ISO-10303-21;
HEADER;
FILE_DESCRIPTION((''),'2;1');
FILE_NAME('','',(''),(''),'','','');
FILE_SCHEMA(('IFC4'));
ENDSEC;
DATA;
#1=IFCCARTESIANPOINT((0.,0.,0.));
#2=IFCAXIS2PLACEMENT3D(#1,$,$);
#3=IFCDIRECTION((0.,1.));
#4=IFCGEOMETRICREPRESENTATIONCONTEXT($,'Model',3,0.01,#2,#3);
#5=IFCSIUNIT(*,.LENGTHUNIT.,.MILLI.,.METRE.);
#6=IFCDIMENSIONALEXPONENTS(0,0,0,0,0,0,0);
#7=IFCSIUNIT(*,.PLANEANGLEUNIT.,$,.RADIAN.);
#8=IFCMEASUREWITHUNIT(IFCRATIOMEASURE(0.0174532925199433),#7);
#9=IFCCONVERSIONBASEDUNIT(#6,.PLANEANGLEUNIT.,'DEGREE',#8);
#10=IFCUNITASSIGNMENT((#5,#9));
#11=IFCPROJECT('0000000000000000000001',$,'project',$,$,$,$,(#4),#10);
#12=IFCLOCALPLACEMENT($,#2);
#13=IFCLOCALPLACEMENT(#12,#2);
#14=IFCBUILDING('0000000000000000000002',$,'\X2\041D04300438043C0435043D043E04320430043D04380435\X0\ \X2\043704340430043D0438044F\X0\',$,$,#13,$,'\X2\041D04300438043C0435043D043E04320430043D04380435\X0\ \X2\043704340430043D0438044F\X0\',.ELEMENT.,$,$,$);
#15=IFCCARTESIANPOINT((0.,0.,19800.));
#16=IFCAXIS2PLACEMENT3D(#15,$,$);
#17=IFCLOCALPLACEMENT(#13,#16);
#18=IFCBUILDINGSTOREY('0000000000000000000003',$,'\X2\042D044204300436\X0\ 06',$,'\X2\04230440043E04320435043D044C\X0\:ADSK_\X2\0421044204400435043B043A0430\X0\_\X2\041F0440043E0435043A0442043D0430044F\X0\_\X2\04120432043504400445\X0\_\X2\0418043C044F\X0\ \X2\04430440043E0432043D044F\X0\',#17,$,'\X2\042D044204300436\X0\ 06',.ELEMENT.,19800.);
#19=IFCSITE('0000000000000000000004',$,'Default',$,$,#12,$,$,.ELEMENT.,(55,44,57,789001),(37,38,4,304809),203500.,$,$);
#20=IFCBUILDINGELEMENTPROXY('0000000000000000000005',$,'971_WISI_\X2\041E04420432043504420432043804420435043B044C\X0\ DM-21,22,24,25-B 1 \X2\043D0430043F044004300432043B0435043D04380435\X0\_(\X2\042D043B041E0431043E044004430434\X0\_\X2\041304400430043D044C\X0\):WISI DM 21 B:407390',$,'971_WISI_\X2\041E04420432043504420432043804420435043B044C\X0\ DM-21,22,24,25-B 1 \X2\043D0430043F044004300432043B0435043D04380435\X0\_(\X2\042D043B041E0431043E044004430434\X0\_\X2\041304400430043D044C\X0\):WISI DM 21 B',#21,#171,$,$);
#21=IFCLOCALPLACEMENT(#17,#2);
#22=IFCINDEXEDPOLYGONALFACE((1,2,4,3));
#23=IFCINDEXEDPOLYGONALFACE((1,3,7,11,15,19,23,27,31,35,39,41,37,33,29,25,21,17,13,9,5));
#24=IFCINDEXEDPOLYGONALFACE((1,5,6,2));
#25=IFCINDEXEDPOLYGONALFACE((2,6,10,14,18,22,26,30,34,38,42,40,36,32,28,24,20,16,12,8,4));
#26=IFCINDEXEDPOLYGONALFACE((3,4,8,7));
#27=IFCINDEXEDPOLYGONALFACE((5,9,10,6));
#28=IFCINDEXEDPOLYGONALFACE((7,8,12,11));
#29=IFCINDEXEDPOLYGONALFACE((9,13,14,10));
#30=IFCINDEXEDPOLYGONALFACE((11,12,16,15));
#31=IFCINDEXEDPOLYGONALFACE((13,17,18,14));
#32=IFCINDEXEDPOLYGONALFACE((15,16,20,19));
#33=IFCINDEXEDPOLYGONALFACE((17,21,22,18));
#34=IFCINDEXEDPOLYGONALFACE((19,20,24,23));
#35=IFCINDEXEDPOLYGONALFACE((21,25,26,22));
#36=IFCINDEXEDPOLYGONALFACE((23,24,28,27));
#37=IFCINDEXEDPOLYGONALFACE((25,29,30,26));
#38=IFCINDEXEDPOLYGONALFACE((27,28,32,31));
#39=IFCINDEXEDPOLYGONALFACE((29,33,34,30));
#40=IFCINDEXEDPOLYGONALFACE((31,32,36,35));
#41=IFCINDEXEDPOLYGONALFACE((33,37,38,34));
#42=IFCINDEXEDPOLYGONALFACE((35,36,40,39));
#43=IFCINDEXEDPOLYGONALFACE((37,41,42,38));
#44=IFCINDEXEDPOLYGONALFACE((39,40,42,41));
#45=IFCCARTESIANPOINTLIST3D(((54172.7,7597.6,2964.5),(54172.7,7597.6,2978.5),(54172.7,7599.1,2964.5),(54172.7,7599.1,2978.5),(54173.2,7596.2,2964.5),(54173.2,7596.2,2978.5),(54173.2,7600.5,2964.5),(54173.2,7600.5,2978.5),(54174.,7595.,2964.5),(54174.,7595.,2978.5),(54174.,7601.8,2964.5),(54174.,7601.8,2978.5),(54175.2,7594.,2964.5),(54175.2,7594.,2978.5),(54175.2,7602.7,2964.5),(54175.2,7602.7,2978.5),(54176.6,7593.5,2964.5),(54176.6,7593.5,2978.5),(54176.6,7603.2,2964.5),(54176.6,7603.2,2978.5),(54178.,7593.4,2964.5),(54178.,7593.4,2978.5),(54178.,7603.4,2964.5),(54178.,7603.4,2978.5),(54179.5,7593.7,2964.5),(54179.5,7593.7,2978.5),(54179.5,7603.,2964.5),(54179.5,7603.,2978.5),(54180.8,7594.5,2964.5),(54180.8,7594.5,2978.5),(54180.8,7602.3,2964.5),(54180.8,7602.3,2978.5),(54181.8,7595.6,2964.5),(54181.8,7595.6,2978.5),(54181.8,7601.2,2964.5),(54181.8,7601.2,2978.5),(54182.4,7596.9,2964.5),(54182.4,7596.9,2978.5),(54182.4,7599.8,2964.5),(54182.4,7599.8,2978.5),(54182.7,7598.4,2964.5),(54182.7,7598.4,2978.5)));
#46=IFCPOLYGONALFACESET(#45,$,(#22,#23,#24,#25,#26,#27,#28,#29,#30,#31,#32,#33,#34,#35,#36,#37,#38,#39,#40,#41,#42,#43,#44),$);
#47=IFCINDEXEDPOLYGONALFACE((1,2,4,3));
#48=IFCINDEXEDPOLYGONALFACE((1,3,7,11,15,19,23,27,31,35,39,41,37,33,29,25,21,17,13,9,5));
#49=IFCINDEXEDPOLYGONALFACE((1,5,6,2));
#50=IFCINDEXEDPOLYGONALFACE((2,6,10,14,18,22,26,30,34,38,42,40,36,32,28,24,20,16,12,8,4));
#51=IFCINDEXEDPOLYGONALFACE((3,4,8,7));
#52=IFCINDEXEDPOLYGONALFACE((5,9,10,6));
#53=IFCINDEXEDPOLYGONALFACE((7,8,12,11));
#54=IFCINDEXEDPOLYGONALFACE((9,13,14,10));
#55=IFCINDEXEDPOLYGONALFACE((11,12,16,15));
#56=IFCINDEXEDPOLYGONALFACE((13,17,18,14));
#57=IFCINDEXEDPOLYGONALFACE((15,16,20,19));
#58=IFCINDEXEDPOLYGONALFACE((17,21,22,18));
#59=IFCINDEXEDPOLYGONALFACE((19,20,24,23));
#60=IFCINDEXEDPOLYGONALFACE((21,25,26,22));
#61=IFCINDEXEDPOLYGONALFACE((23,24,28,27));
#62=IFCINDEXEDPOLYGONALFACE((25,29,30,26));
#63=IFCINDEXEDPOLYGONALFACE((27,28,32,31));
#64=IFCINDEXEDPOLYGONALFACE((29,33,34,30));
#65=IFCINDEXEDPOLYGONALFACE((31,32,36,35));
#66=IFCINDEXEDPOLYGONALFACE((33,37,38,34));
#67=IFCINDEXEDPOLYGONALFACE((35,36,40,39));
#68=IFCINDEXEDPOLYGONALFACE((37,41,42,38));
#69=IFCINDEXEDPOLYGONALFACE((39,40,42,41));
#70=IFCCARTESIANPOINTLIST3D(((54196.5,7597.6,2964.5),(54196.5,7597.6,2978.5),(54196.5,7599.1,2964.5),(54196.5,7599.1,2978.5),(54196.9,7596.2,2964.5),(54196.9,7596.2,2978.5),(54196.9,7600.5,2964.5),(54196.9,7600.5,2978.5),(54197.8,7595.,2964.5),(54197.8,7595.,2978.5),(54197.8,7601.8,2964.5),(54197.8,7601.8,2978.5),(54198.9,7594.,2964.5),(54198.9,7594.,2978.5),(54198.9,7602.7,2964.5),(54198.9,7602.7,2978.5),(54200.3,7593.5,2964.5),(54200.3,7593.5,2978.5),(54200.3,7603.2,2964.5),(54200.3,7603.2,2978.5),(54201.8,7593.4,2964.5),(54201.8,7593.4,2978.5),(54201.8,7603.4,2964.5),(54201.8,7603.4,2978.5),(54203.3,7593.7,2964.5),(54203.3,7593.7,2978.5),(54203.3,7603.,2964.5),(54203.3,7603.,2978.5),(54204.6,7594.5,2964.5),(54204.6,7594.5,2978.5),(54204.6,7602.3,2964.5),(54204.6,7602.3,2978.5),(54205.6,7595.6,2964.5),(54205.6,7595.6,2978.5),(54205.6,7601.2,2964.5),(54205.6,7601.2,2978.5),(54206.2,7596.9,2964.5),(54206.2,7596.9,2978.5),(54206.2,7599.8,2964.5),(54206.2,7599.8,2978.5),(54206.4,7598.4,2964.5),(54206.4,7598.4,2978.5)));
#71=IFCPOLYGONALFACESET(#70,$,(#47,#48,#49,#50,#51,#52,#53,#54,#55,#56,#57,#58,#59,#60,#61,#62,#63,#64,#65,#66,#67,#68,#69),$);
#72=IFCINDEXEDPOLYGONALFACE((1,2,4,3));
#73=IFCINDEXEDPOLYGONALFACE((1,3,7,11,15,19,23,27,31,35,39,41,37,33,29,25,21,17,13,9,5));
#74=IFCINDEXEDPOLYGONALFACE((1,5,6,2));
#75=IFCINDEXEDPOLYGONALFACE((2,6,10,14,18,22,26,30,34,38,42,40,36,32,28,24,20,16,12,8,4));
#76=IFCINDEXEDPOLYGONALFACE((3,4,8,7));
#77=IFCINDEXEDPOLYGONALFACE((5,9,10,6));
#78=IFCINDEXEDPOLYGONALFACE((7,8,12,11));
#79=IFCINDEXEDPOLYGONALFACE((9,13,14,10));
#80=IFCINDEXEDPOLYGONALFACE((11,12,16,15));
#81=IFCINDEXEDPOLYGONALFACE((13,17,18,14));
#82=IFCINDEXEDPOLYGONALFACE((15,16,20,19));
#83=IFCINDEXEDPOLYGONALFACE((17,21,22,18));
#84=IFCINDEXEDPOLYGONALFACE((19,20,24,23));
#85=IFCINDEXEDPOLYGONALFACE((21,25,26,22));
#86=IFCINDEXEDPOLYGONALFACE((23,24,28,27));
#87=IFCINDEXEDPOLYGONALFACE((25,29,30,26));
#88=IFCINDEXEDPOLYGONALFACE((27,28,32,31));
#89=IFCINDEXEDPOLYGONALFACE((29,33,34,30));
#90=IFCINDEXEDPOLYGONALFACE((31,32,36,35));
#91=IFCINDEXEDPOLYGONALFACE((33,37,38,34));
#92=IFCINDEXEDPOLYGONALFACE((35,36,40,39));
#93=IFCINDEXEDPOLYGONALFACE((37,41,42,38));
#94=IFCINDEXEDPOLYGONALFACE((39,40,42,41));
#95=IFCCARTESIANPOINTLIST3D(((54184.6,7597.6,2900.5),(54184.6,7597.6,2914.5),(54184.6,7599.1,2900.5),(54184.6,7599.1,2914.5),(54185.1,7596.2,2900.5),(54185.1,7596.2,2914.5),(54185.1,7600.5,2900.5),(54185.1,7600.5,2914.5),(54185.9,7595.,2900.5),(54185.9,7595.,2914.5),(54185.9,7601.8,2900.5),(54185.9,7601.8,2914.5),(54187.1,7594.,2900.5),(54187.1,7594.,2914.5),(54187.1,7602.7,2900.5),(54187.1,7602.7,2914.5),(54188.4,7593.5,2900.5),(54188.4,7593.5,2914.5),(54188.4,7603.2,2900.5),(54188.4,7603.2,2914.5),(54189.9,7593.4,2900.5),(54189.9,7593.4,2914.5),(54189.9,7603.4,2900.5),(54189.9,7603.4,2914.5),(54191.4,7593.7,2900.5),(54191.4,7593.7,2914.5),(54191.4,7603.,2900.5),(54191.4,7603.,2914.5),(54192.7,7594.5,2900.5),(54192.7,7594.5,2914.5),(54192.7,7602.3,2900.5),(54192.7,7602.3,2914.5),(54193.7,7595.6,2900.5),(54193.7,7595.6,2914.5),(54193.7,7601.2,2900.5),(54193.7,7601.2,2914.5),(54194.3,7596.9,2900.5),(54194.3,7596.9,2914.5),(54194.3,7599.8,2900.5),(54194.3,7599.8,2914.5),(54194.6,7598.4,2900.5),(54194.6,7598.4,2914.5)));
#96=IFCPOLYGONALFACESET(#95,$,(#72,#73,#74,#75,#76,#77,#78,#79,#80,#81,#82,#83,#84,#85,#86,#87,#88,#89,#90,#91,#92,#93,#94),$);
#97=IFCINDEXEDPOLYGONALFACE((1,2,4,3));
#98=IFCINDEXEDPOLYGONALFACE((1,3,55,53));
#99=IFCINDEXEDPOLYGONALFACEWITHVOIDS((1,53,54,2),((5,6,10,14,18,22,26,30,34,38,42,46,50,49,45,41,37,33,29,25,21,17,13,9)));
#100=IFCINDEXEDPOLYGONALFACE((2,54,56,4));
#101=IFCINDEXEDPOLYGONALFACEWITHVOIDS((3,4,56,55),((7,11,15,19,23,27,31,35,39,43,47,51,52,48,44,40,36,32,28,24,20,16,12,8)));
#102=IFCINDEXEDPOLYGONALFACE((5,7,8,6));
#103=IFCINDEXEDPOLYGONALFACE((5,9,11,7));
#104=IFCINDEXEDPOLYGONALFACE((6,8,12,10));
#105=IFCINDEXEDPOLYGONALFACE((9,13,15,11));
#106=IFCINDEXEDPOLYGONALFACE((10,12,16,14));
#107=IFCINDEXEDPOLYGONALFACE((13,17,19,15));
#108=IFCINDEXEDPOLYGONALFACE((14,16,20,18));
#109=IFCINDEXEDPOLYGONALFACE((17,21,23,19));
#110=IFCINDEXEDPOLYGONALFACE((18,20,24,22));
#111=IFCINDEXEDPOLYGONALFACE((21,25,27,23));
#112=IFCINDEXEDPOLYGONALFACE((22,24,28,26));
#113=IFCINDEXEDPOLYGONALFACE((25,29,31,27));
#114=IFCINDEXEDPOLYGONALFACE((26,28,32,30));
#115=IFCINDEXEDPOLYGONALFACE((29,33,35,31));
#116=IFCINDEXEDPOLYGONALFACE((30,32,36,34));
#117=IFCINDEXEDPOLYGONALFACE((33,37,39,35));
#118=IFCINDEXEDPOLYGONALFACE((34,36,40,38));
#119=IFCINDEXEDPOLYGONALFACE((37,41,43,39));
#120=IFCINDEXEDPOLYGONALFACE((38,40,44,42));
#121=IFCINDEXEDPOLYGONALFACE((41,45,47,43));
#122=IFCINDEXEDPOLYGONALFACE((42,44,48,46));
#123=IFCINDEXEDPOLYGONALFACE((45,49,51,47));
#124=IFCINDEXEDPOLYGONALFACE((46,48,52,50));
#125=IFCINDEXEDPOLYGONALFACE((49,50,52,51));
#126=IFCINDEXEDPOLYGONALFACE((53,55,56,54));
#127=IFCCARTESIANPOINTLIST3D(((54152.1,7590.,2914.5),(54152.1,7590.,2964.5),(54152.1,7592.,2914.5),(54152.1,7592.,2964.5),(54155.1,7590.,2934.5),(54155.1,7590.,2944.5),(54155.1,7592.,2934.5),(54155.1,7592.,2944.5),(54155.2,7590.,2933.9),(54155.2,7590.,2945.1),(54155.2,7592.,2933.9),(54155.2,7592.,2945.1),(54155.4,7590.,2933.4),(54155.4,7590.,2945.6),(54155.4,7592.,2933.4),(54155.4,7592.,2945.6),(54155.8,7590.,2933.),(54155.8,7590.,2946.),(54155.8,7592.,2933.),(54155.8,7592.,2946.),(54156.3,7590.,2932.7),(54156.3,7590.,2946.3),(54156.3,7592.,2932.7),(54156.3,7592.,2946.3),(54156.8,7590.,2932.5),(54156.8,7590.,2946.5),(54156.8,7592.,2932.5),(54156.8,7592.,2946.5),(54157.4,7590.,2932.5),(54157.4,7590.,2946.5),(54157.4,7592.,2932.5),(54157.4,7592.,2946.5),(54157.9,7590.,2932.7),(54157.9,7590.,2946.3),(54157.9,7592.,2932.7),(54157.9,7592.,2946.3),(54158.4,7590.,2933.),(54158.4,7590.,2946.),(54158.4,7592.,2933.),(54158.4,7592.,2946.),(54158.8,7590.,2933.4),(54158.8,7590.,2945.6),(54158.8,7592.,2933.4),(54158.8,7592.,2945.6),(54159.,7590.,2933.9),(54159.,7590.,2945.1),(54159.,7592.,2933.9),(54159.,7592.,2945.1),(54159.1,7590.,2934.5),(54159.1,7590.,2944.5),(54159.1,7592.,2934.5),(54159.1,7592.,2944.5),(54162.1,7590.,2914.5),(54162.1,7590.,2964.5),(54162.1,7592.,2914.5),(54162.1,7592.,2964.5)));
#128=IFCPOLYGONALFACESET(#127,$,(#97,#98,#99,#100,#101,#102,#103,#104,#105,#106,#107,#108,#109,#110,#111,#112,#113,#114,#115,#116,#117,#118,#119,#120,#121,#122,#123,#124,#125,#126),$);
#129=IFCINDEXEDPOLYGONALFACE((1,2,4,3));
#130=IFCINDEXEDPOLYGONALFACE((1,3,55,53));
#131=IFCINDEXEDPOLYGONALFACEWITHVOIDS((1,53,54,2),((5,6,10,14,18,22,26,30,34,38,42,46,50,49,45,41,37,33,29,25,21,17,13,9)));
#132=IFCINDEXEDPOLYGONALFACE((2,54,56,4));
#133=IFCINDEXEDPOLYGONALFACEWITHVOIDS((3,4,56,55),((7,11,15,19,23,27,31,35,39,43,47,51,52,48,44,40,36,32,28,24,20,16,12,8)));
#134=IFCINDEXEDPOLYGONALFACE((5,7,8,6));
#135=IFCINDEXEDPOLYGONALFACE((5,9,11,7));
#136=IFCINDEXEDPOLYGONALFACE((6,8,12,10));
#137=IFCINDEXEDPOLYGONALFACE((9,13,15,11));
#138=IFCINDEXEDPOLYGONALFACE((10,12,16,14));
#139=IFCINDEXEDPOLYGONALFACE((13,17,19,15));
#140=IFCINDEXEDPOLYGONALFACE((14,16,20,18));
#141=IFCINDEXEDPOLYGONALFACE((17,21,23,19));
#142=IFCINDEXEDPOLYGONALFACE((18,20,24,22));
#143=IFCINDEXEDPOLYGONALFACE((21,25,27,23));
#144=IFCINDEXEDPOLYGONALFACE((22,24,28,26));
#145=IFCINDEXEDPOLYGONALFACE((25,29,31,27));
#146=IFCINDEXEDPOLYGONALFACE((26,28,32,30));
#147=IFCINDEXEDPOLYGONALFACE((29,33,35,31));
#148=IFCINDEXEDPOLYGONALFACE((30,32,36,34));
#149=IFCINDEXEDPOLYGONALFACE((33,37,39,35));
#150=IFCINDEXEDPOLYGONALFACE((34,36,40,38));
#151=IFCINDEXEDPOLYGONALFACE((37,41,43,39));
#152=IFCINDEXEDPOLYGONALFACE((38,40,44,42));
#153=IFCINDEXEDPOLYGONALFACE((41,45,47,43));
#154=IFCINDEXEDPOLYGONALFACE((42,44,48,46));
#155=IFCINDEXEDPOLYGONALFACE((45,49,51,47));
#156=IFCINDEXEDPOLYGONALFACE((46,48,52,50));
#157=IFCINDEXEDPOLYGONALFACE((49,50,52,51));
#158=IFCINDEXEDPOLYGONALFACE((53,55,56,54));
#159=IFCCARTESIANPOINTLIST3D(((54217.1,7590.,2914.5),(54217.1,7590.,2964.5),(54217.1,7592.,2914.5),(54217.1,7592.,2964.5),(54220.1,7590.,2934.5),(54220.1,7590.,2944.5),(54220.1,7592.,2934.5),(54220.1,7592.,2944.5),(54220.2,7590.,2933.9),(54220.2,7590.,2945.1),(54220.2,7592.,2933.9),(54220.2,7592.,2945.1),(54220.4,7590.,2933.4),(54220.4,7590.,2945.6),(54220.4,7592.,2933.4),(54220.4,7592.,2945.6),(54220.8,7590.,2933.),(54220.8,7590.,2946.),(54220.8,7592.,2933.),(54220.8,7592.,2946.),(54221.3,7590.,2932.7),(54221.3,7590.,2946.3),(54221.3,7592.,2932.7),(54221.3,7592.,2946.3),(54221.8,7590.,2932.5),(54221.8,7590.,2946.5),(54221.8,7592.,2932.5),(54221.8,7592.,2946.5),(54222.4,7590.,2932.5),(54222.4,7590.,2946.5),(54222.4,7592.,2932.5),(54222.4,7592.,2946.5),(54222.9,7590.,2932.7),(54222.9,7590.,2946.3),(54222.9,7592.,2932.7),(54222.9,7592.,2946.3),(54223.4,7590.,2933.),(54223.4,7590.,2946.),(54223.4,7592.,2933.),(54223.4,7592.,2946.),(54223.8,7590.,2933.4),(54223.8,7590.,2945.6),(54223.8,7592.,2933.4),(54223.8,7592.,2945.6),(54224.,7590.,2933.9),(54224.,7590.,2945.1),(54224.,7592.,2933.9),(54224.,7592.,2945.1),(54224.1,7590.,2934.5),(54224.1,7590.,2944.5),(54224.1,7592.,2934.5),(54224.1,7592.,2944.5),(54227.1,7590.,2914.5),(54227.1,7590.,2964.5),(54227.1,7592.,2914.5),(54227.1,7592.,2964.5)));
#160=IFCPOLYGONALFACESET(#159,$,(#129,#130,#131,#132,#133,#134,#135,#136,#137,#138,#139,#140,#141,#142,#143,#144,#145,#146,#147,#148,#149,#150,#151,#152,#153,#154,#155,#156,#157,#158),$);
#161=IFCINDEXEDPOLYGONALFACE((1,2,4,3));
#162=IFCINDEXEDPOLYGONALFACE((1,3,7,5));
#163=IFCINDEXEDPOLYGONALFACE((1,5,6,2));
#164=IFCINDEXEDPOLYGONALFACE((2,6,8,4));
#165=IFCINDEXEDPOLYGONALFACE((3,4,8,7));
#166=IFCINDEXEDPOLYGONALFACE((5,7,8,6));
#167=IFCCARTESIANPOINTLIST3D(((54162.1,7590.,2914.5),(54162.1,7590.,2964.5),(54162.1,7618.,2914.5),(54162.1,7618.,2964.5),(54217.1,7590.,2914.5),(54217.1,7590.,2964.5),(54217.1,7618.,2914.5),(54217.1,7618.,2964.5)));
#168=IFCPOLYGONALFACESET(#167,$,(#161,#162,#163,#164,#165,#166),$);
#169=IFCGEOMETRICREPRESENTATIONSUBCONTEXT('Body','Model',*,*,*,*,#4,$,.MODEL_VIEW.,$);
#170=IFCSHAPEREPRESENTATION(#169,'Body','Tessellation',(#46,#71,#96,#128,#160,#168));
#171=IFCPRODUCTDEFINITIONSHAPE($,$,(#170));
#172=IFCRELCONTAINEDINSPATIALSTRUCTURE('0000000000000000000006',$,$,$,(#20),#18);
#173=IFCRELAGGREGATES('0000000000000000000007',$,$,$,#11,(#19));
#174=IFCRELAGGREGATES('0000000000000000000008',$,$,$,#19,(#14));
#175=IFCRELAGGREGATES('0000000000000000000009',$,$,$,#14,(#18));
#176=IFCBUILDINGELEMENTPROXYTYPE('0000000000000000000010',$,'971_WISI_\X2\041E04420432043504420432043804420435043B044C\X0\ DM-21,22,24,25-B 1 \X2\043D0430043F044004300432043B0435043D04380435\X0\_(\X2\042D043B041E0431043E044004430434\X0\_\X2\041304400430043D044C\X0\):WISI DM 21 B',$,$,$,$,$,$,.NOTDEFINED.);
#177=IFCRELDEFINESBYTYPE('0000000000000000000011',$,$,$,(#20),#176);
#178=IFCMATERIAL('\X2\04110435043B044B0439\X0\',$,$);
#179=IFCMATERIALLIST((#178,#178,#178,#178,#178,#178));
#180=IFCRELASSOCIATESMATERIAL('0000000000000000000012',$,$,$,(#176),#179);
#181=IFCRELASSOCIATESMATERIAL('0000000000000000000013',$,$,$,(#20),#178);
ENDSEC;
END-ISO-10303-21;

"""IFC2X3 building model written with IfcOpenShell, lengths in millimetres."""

from ifc_helpers import new_model, entity, si_unit, converted_unit, direction, frame, frame_2d, origin, place, context, subcontext, project, spatial, polyline, circle_curve, parameter, trimmed, segment, composite_curve, rectangle, circle, outline, extrude, source, transform, mapped, material, material_list, type_object, type_shapes, element, save


model = new_model("IFC2X3")

# Units and contexts
model_context = context("Model", 3, precision=0.01, world=origin(), true_north=direction((0.0, 1.0)))
body_context = subcontext(model_context, "Body", "Model", "MODEL_VIEW")
ifc_project = project(units=[si_unit("LENGTHUNIT", "METRE", prefix="MILLI"), converted_unit("PLANEANGLEUNIT", "DEGREE", entity("IfcRatioMeasure", 0.0174532925199433), si_unit("PLANEANGLEUNIT", "RADIAN"), dimensions=[0, 0, 0, 0, 0, 0, 0])], contexts=[model_context])

# Site, building, storey
site_placement = place(None, frame((0.0, 0.0, 0.0)))
site = spatial("IfcSite", under=ifc_project, at=site_placement, Name="Default", CompositionType="ELEMENT", RefLatitude=(55, 44, 57, 789001), RefLongitude=(37, 38, 4, 304809), RefElevation=203500.0)
building_placement = place(site_placement, origin())
building = spatial("IfcBuilding", under=site, at=building_placement, Name="Наименование здания", LongName="Наименование здания", CompositionType="ELEMENT")
storey_placement = place(building_placement, frame((0.0, 0.0, 19800.0)))
storey = spatial("IfcBuildingStorey", under=building, at=storey_placement, Name="Этаж 06", ObjectType="Уровень:ADSK_Стрелка_Проектная_Вверх_Имя уровня", LongName="Этаж 06", CompositionType="ELEMENT", Elevation=19800.0)

# Building element proxy
ifc_material_1 = material(Name="Белый")
ifc_material_list_1 = material_list([ifc_material_1, ifc_material_1, ifc_material_1, ifc_material_1, ifc_material_1, ifc_material_1])
building_element_proxy_type_1 = type_object("IfcBuildingElementProxyType", Name="971_WISI_Ответвитель DM-21,22,24,25-B 1 направление_(ЭлОборуд_Грань):WISI DM 21 B", PredefinedType="NOTDEFINED", material=ifc_material_list_1)
shared_shape_1 = source(origin(), body_context, "Body", "SweptSolid", [
    extrude(circle(Radius=5.0, at=frame_2d((0.0, 0.0), x_axis=(1.0, 0.0))), frame((11.9, 25.0, 8.4), z_axis=(0.0, 1.0, 0.0), x_axis=(-1.0, 0.0, 0.0)), (0.0, 0.0, 1.0), 14.0),
    extrude(circle(Radius=5.0, at=frame_2d((0.0, 0.0), x_axis=(1.0, 0.0))), frame((-11.8, 25.0, 8.4), z_axis=(0.0, 1.0, 0.0), x_axis=(-1.0, 0.0, 0.0)), (0.0, 0.0, 1.0), 14.0),
    extrude(circle(Radius=5.0, at=frame_2d((0.0, 0.0), x_axis=(1.0, 0.0))), frame((0.0, -39.0, 8.4), z_axis=(0.0, 1.0, 0.0), x_axis=(-1.0, 0.0, 0.0)), (0.0, 0.0, 1.0), 14.0),
    extrude(outline(polyline([(-5.0, -25.0), (5.0, -25.0), (5.0, 25.0), (-5.0, 25.0), (-5.0, -25.0)]), holes=[composite_curve([segment(polyline([(2.0, 5.0), (2.0, -5.0)]), True, "CONTINUOUS"), segment(trimmed(circle_curve(frame_2d((0.0, -5.0), x_axis=(-1.0, 0.0)), 2.0), [parameter(0.0)], [parameter(180.0)], True, "PARAMETER"), False, "CONTINUOUS"), segment(polyline([(-2.0, -5.0), (-2.0, 5.0)]), True, "CONTINUOUS"), segment(trimmed(circle_curve(frame_2d((0.0, 5.0), x_axis=(-1.0, 0.0)), 2.0), [parameter(180.0)], [parameter(0.0)], True, "PARAMETER"), False, "CONTINUOUS")], self_intersect=False)]), frame((32.5, 0.0, 0.0), z_axis=(0.0, 0.0, 1.0), x_axis=(-1.0, 0.0, 0.0)), (0.0, 0.0, 1.0), 2.0),
    extrude(outline(polyline([(-5.0, -25.0), (5.0, -25.0), (5.0, 25.0), (-5.0, 25.0), (-5.0, -25.0)]), holes=[composite_curve([segment(polyline([(-2.0, -5.0), (-2.0, 5.0)]), True, "CONTINUOUS"), segment(trimmed(circle_curve(frame_2d((0.0, 5.0), x_axis=(-1.0, 0.0)), 2.0), [parameter(180.0)], [parameter(0.0)], True, "PARAMETER"), False, "CONTINUOUS"), segment(polyline([(2.0, 5.0), (2.0, -5.0)]), True, "CONTINUOUS"), segment(trimmed(circle_curve(frame_2d((0.0, -5.0), x_axis=(-1.0, 0.0)), 2.0), [parameter(0.0)], [parameter(180.0)], True, "PARAMETER"), False, "CONTINUOUS")], self_intersect=False)]), frame((-32.5, 0.0, 0.0), z_axis=(0.0, 0.0, 1.0), x_axis=(-1.0, 0.0, 0.0)), (0.0, 0.0, 1.0), 2.0),
    extrude(rectangle(XDim=55.0, YDim=50.0, at=frame_2d((0.0, 0.0), x_axis=(1.0, 0.0))), frame((0.0, 0.0, 0.0), z_axis=(0.0, 0.0, 1.0), x_axis=(-1.0, 0.0, 0.0)), (0.0, 0.0, 1.0), 28.0),
])
type_shapes(building_element_proxy_type_1, [shared_shape_1])
for number, where, z_axis, x_axis, name in (
    (1, (54189.6, 7590.0, 2939.5), (0.0, 1.0, 0.0), (-1.0, 0.0, 0.0), "971_WISI_Ответвитель DM-21,22,24,25-B 1 направление_(ЭлОборуд_Грань):WISI DM 21 B:407390"),
):
    element("IfcBuildingElementProxy", number, at=place(storey_placement, frame(where, z_axis=z_axis, x_axis=x_axis)), inside=storey, type_object=building_element_proxy_type_1, material=ifc_material_1, Name=name, ObjectType="971_WISI_Ответвитель DM-21,22,24,25-B 1 направление_(ЭлОборуд_Грань):WISI DM 21 B", context=body_context, shape_type="MappedRepresentation", body=[
        mapped(shared_shape_1, transform((0.0, 0.0, 0.0), scale=1.0)),
    ])

save(model, "model.ifc")
